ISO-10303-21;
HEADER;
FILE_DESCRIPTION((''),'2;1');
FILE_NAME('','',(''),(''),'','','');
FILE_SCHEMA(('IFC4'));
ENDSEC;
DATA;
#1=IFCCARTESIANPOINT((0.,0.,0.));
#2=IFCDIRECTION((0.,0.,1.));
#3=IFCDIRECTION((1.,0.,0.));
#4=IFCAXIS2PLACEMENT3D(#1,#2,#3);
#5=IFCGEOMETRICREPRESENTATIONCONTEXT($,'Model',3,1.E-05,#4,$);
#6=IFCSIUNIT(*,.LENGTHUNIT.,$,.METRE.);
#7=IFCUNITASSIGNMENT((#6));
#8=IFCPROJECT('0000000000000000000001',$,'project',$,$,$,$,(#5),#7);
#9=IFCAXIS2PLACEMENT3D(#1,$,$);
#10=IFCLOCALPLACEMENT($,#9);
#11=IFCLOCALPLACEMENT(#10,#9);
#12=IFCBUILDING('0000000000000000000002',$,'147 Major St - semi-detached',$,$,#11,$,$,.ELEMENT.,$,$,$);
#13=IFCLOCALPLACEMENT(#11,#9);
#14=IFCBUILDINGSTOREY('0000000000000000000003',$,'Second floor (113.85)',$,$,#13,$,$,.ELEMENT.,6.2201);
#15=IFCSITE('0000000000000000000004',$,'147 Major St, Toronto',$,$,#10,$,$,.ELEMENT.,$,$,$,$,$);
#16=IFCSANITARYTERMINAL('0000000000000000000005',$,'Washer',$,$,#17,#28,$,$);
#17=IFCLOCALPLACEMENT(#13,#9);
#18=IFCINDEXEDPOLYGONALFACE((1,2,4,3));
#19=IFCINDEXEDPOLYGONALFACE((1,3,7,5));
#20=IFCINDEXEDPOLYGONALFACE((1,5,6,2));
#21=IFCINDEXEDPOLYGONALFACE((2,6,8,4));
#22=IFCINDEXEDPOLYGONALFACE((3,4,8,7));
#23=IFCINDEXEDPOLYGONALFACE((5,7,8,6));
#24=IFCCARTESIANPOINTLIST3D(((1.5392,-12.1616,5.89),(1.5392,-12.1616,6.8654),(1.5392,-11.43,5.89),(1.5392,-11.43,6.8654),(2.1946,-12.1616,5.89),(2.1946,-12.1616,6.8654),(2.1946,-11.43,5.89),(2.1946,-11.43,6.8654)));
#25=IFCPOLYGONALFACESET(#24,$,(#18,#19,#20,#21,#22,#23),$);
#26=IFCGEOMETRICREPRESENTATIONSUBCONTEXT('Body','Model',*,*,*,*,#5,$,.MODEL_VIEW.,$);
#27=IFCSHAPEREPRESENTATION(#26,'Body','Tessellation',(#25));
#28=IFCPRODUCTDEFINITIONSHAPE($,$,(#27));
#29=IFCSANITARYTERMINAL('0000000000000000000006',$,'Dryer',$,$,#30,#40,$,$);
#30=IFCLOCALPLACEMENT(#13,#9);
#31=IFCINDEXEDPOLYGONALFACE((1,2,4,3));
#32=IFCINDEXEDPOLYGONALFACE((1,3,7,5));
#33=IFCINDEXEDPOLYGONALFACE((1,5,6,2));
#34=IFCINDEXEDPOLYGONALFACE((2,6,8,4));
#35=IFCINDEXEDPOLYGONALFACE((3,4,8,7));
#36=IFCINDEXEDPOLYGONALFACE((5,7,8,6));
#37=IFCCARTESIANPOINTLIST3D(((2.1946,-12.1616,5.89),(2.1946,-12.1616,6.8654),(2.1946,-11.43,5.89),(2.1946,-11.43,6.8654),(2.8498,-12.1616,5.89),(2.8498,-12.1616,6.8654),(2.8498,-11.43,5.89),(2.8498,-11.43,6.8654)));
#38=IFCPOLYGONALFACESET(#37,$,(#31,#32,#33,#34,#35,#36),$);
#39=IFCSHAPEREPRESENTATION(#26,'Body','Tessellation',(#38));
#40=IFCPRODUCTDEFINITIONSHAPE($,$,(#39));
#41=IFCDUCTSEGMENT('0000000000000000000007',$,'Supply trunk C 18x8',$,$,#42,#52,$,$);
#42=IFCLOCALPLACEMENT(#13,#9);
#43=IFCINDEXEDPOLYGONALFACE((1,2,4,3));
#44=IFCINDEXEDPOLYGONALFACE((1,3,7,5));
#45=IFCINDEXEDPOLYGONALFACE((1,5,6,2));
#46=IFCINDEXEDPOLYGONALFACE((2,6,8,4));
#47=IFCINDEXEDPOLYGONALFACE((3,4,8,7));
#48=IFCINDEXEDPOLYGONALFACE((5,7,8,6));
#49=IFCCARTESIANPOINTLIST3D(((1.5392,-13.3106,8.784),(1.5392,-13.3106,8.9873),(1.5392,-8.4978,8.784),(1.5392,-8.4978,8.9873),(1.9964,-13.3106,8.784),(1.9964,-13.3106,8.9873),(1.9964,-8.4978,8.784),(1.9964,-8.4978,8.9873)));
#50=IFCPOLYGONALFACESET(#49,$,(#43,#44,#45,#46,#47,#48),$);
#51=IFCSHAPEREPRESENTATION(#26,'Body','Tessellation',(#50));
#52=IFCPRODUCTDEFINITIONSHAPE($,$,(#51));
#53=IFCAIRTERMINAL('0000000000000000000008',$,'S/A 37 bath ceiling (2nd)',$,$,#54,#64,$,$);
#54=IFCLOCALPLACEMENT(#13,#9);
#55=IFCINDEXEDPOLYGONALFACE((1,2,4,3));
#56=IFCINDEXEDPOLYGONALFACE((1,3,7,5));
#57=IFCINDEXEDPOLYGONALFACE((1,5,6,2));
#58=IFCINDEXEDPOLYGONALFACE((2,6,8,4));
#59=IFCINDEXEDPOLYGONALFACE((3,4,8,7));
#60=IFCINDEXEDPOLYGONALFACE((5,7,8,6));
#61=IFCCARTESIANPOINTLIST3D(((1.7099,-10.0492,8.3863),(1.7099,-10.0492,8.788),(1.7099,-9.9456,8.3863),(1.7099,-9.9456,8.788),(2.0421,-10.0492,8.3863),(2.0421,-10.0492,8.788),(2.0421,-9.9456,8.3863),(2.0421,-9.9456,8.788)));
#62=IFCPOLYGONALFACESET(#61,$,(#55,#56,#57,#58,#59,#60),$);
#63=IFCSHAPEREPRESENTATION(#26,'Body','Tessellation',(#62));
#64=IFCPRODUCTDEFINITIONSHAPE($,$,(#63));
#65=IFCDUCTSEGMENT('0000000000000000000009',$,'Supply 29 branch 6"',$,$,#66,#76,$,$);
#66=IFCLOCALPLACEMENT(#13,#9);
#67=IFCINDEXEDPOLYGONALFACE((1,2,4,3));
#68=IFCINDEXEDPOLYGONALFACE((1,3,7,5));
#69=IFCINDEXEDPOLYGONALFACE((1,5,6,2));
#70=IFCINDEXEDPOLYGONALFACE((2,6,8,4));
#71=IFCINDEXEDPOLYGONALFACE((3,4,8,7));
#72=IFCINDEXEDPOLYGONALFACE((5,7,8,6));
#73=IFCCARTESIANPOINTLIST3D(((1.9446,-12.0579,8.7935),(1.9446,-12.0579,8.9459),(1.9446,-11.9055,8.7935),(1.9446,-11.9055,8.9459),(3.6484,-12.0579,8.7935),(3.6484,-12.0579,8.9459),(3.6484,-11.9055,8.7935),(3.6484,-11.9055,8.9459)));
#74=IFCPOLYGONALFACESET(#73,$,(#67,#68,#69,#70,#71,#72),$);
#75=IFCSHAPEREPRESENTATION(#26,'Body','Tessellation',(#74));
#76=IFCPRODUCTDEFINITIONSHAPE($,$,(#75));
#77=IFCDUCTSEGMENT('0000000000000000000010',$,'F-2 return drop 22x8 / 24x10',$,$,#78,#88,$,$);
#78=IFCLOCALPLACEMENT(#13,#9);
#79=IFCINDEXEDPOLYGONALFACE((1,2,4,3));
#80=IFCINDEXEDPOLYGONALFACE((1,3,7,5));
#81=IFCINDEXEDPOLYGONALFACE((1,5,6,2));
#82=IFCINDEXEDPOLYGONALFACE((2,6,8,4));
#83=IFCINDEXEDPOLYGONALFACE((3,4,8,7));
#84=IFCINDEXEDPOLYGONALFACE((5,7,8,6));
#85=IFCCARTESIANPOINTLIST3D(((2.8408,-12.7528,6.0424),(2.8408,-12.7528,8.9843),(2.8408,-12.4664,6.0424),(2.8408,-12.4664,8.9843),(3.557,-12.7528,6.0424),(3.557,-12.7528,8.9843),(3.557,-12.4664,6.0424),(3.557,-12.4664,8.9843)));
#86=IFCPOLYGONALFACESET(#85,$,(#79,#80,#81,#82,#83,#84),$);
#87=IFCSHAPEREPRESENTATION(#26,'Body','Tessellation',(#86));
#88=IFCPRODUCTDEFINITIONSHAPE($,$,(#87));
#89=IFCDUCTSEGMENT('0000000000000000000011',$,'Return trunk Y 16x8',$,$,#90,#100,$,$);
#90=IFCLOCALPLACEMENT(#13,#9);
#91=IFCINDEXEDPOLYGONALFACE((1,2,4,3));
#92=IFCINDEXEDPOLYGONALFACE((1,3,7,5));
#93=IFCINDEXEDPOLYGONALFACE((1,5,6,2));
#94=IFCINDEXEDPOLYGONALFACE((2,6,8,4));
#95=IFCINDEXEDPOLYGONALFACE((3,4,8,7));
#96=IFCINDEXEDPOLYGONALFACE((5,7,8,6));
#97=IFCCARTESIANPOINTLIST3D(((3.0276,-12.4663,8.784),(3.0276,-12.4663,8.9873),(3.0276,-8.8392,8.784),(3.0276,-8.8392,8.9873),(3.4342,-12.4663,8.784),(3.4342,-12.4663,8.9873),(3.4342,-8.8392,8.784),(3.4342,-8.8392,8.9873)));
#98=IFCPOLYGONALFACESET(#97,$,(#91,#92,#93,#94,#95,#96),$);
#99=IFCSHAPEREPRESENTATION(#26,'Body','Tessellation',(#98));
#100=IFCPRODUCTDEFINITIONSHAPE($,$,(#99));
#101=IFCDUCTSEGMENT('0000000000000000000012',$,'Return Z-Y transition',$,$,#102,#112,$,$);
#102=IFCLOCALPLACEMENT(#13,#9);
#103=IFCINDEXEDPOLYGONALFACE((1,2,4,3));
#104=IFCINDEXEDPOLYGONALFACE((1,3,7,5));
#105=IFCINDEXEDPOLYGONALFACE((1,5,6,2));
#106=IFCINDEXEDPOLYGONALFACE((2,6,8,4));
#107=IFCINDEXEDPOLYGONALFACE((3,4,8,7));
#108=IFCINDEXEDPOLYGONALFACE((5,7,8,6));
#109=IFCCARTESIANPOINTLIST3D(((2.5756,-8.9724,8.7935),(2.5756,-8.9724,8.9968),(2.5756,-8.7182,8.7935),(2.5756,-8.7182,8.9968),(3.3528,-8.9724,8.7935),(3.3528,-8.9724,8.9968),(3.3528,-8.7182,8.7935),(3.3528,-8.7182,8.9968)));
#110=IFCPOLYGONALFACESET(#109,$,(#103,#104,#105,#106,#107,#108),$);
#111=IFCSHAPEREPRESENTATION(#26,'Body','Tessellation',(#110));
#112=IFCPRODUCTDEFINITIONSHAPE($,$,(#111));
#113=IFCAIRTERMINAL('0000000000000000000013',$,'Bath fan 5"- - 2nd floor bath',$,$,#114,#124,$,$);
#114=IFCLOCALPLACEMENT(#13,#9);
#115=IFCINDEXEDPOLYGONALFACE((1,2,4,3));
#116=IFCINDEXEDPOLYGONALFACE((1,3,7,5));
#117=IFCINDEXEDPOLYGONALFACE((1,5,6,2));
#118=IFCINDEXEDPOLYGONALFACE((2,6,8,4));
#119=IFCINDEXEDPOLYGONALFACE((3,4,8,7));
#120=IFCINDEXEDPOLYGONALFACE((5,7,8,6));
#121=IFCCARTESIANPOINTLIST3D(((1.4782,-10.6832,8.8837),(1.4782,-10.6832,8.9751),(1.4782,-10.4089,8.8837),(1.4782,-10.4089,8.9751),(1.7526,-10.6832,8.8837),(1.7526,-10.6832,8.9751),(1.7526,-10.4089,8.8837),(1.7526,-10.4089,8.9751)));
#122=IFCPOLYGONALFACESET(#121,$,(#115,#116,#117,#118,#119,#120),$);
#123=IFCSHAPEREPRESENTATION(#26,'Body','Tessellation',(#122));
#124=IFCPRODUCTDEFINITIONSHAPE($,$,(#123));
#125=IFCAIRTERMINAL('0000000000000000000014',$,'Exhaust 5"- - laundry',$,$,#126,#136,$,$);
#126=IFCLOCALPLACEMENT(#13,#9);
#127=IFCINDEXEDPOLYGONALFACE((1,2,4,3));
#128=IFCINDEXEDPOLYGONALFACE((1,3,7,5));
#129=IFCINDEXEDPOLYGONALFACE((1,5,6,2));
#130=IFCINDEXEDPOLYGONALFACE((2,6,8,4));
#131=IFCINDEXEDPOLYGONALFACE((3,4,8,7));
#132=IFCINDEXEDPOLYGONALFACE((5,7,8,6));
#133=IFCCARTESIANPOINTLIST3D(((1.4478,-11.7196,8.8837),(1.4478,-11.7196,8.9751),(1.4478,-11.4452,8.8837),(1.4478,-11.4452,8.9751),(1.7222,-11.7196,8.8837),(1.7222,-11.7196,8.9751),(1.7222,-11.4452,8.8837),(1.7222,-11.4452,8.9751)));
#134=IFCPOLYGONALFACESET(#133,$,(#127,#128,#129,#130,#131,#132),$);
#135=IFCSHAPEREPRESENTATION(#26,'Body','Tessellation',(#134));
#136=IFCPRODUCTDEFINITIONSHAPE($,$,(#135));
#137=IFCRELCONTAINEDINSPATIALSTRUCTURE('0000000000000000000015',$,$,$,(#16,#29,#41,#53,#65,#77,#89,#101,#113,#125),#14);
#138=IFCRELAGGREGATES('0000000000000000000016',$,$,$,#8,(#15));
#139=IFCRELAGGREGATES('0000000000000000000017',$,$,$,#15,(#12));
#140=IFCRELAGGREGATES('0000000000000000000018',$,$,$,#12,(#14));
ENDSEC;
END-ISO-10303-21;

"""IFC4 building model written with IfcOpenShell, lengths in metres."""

from ifc_helpers import new_model, si_unit, frame, origin, origin_with_axes, place, context, subcontext, project, spatial, rectangle, extrude, element, save


model = new_model("IFC4")

# Units and contexts
model_context = context("Model", 3, precision=1e-05, world=origin_with_axes())
body_context = subcontext(model_context, "Body", "Model", "MODEL_VIEW")
ifc_project = project(units=[si_unit("LENGTHUNIT", "METRE")], contexts=[model_context])

# Site, building, storey
site_placement = place(None, origin())
site = spatial("IfcSite", under=ifc_project, at=site_placement, Name="147 Major St, Toronto", CompositionType="ELEMENT")
building_placement = place(site_placement, origin())
building = spatial("IfcBuilding", under=site, at=building_placement, Name="147 Major St - semi-detached", CompositionType="ELEMENT")
storey_placement = place(building_placement, origin())
storey = spatial("IfcBuildingStorey", under=building, at=storey_placement, Name="Second floor (113.85)", CompositionType="ELEMENT", Elevation=6.2201)

# Sanitary terminals
for number, where, name in (
    (1, (1.8669, -11.7958, 5.89), "Washer"),
    (2, (2.5222, -11.7958, 5.89), "Dryer"),
):
    element("IfcSanitaryTerminal", number, at=place(storey_placement, frame(where)), inside=storey, Name=name, context=body_context, shape_type="SweptSolid", body=[
        extrude(rectangle(XDim=0.6553, YDim=0.7315), origin_with_axes(), (0.0, 0.0, 1.0), 0.9754),
    ])

# Duct segment
duct_segment_1_placement = place(storey_placement, frame((1.7678, -10.9042, 8.784)))
element("IfcDuctSegment", 3, at=duct_segment_1_placement, inside=storey, Name="Supply trunk C 18x8", context=body_context, shape_type="SweptSolid", body=[
    extrude(rectangle(XDim=0.4572, YDim=4.8128), origin_with_axes(), (0.0, 0.0, 1.0), 0.2033),
])

# Air terminal
air_terminal_placement = place(storey_placement, frame((1.876, -9.9974, 8.3863)))
element("IfcAirTerminal", 4, at=air_terminal_placement, inside=storey, Name="S/A 37 bath ceiling (2nd)", context=body_context, shape_type="SweptSolid", body=[
    extrude(rectangle(XDim=0.3322, YDim=0.1036), origin_with_axes(), (0.0, 0.0, 1.0), 0.4017),
])

# Duct segments
duct_segment_2_placement = place(storey_placement, frame((2.7965, -11.9817, 8.7935)))
element("IfcDuctSegment", 5, at=duct_segment_2_placement, inside=storey, Name="Supply 29 branch 6\"", context=body_context, shape_type="SweptSolid", body=[
    extrude(rectangle(XDim=1.7038, YDim=0.1524), origin_with_axes(), (0.0, 0.0, 1.0), 0.1524),
])
duct_segment_3_placement = place(storey_placement, frame((3.1989, -12.6096, 6.0424)))
element("IfcDuctSegment", 6, at=duct_segment_3_placement, inside=storey, Name="F-2 return drop 22x8 / 24x10", context=body_context, shape_type="SweptSolid", body=[
    extrude(rectangle(XDim=0.7163, YDim=0.2865), origin_with_axes(), (0.0, 0.0, 1.0), 2.9419),
])
duct_segment_4_placement = place(storey_placement, frame((3.2309, -10.6528, 8.784)))
element("IfcDuctSegment", 7, at=duct_segment_4_placement, inside=storey, Name="Return trunk Y 16x8", context=body_context, shape_type="SweptSolid", body=[
    extrude(rectangle(XDim=0.4066, YDim=3.6271), origin_with_axes(), (0.0, 0.0, 1.0), 0.2033),
])
duct_segment_5_placement = place(storey_placement, frame((2.9642, -8.8453, 8.7935)))
element("IfcDuctSegment", 8, at=duct_segment_5_placement, inside=storey, Name="Return Z-Y transition", context=body_context, shape_type="SweptSolid", body=[
    extrude(rectangle(XDim=0.7772, YDim=0.2542), origin_with_axes(), (0.0, 0.0, 1.0), 0.2033),
])

# Air terminals
for number, where, name in (
    (9, (1.6154, -10.5461, 8.8837), "Bath fan 5\"- - 2nd floor bath"),
    (10, (1.585, -11.5824, 8.8837), "Exhaust 5\"- - laundry"),
):
    element("IfcAirTerminal", number, at=place(storey_placement, frame(where)), inside=storey, Name=name, context=body_context, shape_type="SweptSolid", body=[
        extrude(rectangle(XDim=0.2743, YDim=0.2743), origin_with_axes(), (0.0, 0.0, 1.0), 0.0914),
    ])

save(model, "model.ifc")
